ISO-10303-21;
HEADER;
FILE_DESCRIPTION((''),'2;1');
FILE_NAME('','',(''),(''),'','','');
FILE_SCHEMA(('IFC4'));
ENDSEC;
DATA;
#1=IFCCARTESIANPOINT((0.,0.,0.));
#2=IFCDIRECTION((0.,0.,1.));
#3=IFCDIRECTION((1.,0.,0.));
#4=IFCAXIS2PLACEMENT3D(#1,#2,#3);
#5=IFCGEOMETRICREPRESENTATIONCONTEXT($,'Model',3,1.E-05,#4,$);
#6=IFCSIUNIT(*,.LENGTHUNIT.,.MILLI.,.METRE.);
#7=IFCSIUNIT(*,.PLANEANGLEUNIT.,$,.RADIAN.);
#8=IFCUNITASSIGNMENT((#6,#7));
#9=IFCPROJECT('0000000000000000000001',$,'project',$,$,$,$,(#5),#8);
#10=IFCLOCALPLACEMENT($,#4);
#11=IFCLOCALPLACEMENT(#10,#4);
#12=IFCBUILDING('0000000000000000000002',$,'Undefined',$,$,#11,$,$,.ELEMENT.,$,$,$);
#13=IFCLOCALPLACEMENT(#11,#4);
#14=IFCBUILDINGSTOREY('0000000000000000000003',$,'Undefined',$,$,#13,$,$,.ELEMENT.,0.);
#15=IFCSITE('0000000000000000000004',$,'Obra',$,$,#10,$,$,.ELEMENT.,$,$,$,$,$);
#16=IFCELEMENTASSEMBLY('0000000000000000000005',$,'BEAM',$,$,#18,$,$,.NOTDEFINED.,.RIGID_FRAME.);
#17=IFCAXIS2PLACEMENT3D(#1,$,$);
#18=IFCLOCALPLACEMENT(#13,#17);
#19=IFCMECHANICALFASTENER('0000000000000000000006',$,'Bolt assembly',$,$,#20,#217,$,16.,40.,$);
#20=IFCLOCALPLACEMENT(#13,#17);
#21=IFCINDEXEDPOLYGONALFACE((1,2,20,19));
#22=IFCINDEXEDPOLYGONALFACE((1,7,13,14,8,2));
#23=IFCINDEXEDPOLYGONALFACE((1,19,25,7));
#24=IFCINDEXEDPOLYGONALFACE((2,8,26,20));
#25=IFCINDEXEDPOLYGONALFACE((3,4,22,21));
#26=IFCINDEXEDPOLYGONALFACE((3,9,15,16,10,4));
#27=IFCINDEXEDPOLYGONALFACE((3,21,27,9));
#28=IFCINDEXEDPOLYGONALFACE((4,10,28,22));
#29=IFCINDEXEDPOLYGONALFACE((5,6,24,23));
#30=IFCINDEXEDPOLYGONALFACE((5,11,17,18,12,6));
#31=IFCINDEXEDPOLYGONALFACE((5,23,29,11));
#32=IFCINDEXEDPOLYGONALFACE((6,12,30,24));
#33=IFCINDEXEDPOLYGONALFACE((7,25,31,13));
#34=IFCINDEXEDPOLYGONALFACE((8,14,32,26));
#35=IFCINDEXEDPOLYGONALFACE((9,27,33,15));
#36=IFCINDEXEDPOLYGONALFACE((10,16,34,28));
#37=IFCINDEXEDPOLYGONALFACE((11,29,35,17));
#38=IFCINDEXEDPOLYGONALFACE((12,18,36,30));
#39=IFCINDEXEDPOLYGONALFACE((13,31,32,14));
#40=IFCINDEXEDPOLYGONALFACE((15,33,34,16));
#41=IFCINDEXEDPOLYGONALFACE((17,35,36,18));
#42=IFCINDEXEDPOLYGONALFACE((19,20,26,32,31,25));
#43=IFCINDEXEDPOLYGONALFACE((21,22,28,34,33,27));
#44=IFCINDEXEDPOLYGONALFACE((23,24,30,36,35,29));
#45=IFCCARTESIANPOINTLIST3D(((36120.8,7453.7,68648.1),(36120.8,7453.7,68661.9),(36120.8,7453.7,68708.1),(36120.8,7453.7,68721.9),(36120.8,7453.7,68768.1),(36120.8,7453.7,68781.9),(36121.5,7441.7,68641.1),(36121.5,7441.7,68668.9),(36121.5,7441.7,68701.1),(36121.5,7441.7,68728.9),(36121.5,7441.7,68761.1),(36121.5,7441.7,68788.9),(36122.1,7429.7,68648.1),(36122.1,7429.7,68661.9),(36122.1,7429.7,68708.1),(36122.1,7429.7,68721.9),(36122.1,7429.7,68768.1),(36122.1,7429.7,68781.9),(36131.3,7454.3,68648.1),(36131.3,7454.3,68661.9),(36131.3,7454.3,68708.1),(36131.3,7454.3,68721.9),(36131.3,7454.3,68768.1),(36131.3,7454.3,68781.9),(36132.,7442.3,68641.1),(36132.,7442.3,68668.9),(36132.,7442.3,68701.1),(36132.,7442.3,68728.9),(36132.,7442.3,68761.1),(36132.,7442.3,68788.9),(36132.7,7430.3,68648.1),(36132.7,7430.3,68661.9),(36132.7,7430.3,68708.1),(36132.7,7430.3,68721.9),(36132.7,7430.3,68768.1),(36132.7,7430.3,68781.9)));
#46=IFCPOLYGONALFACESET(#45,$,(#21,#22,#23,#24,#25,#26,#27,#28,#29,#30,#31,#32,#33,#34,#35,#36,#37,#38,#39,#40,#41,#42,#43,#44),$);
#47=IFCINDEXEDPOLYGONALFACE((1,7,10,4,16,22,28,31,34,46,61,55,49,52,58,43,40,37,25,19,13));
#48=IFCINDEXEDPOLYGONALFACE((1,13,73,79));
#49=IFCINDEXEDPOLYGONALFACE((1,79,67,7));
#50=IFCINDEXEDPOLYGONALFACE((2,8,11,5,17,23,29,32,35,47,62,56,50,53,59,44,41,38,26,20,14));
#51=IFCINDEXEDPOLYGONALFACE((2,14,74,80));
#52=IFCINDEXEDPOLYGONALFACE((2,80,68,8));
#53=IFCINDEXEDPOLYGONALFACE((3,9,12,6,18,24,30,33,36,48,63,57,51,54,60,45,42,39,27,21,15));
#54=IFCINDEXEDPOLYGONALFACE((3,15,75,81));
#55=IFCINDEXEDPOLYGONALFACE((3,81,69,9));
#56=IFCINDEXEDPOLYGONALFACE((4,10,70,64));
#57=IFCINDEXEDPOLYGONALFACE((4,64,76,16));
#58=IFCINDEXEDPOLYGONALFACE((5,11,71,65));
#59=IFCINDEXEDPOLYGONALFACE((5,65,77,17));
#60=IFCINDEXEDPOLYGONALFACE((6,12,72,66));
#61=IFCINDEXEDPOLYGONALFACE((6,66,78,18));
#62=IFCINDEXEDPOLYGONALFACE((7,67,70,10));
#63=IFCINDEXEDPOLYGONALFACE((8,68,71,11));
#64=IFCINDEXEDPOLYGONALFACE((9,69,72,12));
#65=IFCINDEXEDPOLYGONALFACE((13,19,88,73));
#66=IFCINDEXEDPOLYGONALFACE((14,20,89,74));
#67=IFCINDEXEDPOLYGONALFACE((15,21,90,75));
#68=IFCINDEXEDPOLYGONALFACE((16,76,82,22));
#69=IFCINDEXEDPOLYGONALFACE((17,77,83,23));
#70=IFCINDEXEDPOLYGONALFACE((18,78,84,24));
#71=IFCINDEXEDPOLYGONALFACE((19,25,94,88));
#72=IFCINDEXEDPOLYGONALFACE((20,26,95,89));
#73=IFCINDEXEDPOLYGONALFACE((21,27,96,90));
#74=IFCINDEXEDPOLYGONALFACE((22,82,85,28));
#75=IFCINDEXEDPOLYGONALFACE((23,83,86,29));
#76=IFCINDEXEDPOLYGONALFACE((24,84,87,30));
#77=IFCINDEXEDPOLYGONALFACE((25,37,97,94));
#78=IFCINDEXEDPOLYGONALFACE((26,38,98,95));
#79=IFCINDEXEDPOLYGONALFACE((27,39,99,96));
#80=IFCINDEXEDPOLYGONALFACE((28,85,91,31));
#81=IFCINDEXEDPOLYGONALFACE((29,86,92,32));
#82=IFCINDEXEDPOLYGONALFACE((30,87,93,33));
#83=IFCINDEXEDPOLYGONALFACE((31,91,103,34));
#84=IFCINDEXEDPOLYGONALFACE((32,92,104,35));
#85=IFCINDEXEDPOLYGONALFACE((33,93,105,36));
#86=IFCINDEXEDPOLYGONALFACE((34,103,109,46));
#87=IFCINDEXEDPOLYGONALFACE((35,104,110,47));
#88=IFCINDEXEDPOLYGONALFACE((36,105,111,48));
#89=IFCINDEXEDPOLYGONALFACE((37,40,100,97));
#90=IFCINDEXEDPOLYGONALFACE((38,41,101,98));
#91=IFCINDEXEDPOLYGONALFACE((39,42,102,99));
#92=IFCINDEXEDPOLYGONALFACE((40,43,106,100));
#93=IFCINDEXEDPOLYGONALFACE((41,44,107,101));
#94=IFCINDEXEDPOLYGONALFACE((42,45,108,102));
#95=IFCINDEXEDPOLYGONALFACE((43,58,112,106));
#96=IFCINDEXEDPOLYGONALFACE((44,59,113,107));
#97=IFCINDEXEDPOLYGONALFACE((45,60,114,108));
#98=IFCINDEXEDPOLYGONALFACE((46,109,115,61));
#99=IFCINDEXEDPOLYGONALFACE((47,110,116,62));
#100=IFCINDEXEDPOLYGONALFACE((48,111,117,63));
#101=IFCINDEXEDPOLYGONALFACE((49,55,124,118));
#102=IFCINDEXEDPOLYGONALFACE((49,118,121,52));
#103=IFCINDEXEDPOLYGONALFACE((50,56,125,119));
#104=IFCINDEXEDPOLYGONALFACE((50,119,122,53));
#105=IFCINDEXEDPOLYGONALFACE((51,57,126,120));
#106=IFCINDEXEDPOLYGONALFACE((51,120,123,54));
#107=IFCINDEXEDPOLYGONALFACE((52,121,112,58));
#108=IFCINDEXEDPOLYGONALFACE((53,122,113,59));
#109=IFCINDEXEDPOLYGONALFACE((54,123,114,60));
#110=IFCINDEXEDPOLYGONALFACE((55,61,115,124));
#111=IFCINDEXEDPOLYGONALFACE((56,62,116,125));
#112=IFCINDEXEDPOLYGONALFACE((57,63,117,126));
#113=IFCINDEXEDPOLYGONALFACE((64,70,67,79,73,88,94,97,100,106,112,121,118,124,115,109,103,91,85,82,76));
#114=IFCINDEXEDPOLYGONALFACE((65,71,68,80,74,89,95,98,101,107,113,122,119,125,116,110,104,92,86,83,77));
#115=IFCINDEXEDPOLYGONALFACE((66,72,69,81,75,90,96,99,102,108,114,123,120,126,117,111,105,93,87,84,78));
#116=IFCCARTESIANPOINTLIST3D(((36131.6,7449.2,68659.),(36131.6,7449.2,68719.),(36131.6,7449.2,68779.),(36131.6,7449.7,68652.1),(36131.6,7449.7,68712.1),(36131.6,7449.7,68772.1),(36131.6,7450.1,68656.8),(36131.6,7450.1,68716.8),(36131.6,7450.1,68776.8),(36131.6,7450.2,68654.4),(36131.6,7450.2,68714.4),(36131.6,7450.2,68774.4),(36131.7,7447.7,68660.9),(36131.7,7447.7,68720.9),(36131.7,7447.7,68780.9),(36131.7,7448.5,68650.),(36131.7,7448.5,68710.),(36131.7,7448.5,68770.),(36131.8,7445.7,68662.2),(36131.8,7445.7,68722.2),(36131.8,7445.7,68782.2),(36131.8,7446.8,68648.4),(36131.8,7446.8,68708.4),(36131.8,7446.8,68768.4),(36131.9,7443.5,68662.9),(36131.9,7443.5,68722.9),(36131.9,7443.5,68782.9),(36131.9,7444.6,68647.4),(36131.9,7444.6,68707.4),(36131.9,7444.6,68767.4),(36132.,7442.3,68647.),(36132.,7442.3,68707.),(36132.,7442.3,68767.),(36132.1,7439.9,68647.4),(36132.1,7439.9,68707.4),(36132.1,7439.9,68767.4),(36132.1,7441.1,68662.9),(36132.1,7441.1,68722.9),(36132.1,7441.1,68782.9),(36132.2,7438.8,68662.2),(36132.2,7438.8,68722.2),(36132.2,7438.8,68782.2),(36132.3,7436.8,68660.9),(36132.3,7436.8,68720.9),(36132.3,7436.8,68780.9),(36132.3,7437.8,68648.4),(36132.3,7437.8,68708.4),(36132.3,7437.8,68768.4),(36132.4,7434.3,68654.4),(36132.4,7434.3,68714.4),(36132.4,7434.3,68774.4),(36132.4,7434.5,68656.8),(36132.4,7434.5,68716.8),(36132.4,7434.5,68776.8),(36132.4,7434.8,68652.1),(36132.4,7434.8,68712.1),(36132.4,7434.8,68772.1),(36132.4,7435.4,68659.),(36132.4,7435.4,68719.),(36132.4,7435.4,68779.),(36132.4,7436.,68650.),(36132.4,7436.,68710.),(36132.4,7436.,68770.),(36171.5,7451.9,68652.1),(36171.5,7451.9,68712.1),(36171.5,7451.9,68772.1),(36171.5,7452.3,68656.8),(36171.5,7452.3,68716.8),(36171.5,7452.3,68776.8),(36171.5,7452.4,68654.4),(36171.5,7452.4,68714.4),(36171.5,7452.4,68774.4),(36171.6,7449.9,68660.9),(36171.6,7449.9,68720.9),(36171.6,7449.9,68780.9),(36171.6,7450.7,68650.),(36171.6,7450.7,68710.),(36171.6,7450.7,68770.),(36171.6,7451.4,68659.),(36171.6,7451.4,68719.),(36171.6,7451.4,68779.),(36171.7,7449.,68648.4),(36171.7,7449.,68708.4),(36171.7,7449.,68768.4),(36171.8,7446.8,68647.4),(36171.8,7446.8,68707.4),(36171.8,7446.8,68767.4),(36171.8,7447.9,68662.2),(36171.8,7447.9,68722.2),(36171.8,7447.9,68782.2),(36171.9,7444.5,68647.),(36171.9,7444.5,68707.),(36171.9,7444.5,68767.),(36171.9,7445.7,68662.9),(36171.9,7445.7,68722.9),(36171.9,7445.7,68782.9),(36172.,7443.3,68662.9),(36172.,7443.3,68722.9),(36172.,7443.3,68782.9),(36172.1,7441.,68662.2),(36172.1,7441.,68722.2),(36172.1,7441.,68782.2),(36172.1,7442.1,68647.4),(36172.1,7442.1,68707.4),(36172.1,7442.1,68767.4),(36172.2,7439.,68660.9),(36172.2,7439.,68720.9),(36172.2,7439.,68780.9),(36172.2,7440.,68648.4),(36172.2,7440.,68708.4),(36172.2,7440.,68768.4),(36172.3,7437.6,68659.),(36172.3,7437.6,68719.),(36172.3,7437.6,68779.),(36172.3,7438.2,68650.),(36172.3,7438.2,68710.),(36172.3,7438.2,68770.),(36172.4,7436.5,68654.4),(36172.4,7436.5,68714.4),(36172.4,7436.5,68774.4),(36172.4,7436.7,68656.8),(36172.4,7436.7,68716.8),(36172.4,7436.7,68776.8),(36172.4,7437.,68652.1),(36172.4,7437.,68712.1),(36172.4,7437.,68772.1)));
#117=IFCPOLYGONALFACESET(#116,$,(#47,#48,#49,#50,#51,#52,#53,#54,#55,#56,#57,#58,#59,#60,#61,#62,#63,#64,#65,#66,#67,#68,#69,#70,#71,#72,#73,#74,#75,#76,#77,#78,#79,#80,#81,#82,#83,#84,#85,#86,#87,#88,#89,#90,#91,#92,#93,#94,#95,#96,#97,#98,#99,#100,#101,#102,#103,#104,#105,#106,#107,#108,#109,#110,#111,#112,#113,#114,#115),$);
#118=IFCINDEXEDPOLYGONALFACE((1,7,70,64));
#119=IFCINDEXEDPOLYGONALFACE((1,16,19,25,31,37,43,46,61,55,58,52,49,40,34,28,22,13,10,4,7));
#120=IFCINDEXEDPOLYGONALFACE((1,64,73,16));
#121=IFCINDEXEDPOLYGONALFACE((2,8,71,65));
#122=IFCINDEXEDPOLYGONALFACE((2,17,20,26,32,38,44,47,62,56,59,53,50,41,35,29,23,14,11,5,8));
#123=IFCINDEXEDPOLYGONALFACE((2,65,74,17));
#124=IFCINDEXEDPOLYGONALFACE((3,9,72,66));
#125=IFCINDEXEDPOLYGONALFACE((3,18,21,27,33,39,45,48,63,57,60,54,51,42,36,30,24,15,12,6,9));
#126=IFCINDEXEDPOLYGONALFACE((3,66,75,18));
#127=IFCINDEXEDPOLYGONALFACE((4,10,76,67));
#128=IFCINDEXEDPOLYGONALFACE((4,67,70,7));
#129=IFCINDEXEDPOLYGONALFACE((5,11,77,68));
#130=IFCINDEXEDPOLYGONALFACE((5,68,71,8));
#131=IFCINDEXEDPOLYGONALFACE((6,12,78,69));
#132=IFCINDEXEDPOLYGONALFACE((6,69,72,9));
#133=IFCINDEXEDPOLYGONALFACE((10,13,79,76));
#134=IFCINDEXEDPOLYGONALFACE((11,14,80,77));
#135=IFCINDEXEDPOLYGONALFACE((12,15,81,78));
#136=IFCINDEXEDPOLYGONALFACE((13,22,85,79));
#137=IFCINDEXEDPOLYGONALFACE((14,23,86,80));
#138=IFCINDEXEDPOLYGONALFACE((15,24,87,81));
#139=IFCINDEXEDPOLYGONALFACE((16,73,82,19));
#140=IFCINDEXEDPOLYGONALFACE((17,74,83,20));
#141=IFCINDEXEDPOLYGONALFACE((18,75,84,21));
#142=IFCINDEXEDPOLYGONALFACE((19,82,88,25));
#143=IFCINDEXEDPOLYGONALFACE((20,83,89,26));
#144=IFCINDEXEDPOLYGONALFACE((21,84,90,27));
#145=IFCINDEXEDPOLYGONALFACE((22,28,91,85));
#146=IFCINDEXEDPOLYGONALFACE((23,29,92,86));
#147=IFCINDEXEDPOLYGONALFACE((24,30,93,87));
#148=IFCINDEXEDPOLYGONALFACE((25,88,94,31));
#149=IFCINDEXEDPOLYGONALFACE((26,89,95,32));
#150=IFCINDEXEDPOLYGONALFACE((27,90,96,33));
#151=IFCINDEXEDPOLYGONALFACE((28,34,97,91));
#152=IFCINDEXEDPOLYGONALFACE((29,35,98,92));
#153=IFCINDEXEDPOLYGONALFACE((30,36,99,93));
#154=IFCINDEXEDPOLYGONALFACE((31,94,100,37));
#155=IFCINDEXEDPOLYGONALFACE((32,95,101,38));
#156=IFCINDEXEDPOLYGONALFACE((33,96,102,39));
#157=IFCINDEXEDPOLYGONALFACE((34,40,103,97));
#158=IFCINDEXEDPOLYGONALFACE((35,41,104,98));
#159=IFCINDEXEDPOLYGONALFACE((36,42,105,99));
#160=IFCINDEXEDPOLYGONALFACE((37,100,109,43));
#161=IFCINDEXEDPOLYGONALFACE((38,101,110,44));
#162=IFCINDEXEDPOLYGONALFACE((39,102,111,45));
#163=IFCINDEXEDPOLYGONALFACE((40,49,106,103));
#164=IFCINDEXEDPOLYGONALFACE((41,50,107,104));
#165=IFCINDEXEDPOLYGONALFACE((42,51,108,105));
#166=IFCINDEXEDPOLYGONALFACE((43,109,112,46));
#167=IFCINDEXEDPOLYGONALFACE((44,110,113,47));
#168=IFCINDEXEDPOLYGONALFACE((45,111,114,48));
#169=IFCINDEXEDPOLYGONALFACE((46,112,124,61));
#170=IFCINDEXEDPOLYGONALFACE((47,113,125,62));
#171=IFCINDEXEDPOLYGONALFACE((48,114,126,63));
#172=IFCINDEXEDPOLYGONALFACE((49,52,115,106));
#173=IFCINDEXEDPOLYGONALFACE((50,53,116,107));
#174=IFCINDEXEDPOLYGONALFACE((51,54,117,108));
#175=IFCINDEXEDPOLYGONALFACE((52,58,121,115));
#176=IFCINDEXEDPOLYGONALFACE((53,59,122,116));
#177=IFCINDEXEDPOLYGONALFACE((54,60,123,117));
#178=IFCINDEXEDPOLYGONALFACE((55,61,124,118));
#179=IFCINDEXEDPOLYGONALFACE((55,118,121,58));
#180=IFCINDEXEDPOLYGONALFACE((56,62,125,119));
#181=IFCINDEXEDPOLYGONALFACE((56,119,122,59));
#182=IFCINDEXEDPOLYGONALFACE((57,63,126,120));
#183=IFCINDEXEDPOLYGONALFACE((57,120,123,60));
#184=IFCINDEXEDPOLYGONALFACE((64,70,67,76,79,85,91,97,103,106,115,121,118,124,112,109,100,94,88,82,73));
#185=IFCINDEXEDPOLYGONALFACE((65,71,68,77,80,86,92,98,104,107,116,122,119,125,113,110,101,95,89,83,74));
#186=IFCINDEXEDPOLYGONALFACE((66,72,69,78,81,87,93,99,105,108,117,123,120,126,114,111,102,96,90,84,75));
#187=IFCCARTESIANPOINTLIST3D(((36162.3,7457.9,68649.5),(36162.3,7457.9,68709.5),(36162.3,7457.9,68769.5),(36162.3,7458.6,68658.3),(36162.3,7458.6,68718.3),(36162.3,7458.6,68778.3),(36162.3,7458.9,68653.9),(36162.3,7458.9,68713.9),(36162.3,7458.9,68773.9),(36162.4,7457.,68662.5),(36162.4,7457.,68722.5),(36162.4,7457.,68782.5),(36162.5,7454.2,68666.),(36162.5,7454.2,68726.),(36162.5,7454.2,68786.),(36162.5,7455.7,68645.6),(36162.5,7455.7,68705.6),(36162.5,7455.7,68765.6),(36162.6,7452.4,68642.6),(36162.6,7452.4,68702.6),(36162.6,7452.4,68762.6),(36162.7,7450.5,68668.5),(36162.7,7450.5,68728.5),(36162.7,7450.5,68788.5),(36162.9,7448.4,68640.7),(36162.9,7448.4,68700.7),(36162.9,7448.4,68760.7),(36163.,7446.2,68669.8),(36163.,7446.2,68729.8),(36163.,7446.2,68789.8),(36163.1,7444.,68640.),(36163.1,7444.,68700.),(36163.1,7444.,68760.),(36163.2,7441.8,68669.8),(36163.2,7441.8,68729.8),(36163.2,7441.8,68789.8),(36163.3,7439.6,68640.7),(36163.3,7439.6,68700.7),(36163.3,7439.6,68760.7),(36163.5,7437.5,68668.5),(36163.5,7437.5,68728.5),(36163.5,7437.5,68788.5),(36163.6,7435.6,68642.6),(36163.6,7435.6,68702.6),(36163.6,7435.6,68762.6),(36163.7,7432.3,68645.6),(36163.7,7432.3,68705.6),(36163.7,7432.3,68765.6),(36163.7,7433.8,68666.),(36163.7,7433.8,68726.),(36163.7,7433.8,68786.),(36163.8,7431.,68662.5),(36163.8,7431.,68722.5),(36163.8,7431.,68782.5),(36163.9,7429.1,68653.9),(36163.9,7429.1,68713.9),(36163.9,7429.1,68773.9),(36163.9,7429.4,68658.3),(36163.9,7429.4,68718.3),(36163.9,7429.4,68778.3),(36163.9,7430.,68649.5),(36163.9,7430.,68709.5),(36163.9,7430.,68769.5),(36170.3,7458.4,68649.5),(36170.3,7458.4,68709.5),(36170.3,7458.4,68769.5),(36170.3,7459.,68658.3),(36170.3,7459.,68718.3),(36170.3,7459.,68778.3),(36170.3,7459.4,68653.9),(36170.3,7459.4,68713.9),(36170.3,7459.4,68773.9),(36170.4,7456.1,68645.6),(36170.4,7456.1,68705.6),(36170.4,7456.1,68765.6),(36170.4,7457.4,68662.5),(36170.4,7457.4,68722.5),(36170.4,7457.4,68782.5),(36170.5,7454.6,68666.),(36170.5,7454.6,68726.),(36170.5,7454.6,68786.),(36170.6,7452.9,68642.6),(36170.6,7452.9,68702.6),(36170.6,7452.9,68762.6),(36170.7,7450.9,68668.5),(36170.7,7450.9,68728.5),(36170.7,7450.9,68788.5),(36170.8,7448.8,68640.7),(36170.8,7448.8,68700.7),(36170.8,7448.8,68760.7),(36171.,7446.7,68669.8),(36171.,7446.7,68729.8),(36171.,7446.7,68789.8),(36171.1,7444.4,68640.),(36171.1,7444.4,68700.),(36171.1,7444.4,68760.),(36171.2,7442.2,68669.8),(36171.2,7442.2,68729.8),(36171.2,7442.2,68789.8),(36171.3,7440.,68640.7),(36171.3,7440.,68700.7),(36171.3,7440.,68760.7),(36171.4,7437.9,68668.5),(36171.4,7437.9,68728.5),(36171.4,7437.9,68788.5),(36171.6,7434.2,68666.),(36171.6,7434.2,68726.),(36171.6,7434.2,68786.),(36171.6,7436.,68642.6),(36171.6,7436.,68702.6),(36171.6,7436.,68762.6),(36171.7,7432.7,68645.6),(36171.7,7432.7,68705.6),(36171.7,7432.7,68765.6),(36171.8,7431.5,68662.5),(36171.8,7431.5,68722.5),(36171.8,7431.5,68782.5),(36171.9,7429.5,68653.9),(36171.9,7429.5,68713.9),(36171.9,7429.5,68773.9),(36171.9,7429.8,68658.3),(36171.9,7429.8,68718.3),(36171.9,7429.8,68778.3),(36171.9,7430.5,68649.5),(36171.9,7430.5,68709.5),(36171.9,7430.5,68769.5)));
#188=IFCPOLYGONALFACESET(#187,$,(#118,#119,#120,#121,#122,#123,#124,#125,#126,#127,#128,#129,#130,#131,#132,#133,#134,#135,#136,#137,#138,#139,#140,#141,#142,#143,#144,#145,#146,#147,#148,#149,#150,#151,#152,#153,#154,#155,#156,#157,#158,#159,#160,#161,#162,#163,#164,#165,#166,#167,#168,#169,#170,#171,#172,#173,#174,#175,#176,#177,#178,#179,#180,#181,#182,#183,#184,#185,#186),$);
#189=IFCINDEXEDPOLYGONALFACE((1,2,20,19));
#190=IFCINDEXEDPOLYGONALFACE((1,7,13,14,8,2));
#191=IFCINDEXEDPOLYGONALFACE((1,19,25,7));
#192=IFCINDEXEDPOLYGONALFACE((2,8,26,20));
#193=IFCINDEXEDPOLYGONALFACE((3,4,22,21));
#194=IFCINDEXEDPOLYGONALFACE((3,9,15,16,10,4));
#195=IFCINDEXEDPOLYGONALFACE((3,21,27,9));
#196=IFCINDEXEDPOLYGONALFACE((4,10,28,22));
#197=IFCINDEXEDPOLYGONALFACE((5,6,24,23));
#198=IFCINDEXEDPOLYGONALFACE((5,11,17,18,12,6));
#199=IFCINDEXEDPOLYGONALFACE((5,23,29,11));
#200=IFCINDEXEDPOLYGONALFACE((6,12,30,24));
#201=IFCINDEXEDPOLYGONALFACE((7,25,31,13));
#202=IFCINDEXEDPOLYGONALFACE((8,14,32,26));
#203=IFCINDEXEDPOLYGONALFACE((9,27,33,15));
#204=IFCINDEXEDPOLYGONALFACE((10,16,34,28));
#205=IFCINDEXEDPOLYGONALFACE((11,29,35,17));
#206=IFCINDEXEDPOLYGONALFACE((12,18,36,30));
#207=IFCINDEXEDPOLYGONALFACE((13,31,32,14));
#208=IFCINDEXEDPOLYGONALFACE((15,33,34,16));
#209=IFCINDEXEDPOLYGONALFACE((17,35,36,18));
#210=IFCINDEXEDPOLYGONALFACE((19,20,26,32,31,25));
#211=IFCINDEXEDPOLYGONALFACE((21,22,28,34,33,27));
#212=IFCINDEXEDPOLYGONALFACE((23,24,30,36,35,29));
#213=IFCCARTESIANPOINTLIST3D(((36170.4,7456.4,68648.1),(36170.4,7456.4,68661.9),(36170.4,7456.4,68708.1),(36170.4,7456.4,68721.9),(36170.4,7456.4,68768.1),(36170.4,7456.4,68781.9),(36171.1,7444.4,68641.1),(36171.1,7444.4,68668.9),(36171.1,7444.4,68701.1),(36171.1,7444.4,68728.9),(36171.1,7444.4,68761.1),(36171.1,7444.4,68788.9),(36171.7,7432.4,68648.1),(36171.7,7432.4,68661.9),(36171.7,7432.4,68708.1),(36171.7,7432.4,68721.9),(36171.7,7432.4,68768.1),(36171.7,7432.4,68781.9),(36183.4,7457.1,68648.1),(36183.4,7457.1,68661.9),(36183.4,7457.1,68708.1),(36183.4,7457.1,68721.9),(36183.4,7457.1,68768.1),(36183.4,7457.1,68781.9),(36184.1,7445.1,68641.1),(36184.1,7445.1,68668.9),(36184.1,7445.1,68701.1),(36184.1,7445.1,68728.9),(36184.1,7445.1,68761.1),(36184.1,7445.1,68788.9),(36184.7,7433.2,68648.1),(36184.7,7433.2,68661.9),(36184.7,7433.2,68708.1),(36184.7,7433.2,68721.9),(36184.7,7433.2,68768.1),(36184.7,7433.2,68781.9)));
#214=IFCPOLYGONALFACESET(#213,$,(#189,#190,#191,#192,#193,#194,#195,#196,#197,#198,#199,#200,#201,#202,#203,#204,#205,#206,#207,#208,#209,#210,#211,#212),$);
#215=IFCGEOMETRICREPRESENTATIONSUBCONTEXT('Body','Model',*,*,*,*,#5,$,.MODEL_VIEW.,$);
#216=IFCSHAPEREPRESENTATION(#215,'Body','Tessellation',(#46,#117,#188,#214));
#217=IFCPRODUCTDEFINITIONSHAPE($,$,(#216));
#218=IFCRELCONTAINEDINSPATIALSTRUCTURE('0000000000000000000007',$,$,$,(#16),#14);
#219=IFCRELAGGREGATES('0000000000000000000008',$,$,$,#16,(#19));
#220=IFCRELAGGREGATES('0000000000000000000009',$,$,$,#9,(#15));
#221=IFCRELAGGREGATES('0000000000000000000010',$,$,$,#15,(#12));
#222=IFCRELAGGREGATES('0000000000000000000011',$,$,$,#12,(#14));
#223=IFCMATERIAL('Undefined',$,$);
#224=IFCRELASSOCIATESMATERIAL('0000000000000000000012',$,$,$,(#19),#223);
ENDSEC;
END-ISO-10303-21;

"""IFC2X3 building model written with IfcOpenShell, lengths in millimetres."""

from ifc_helpers import new_model, si_unit, frame, origin_with_axes, origin_2d_with_axis, place, context, subcontext, project, spatial, polyline, circle, outline, extrude, source, transform, mapped, material, element, aggregate, save


model = new_model("IFC2X3")

# Units and contexts
model_context = context("Model", 3, precision=1e-05, world=origin_with_axes())
body_context = subcontext(model_context, "Body", "Model", "MODEL_VIEW")
ifc_project = project(units=[si_unit("LENGTHUNIT", "METRE", prefix="MILLI"), si_unit("PLANEANGLEUNIT", "RADIAN")], contexts=[model_context])

# Site, building, storey
site_placement = place(None, origin_with_axes())
site = spatial("IfcSite", under=ifc_project, at=site_placement, Name="Obra", CompositionType="ELEMENT")
building_placement = place(site_placement, origin_with_axes())
building = spatial("IfcBuilding", under=site, at=building_placement, Name="Undefined", CompositionType="ELEMENT")
storey_placement = place(building_placement, origin_with_axes())
storey = spatial("IfcBuildingStorey", under=building, at=storey_placement, Name="Undefined", CompositionType="ELEMENT", Elevation=0.0)

# Shared definitions
ifc_material_1 = material(Name="Undefined")
shared_shape_1 = source(origin_with_axes(), body_context, "Body", "SweptSolid", [
    extrude(outline(polyline([(13.9, 0.0), (6.9, 12.0), (-6.9, 12.0), (-13.9, 0.0), (-6.9, -12.0), (6.9, -12.0), (13.9, 0.0)])), frame((0.0, -44.8, 0.0), z_axis=(0.0, 1.0, 0.0), x_axis=(1.0, 0.0, 0.0)), (0.0, 0.0, 1.0), 10.6),
    extrude(circle(Radius=8.0, at=origin_2d_with_axis()), frame((0.0, -34.2, 0.0), z_axis=(0.0, 1.0, 0.0), x_axis=(1.0, 0.0, 0.0)), (0.0, 0.0, 1.0), 40.0),
    extrude(circle(Radius=15.0, at=origin_2d_with_axis()), frame((0.0, -3.1, 0.0), z_axis=(0.0, 1.0, 0.0), x_axis=(1.0, 0.0, 0.0)), (0.0, 0.0, 1.0), 8.0),
    extrude(outline(polyline([(13.9, 0.0), (6.9, 12.0), (-6.9, 12.0), (-13.9, 0.0), (-6.9, -12.0), (6.9, -12.0), (13.9, 0.0)])), frame((0.0, 4.9, 0.0), z_axis=(0.0, 1.0, 0.0), x_axis=(1.0, 0.0, 0.0)), (0.0, 0.0, 1.0), 13.0),
])

# Element assembly, mechanical fastener
assembly_1_placement = place(storey_placement, origin_with_axes())
assembly_1 = element("IfcElementAssembly", 1, at=assembly_1_placement, inside=storey, Name="BEAM", AssemblyPlace="NOTDEFINED", PredefinedType="RIGID_FRAME")
mechanical_fastener_1_placement = place(assembly_1_placement, frame((36163.4, 7494.1, 68835.0), z_axis=(0.055152, -0.998478, 0.0), x_axis=(0.0, 0.0, -1.0)))
mechanical_fastener_1 = element("IfcMechanicalFastener", 2, at=mechanical_fastener_1_placement, material=ifc_material_1, Name="Bolt assembly", NominalDiameter=16.0, NominalLength=40.0, context=body_context, shape_type="MappedRepresentation", body=[
    mapped(shared_shape_1, transform((60.0, 0.0, 50.0))),
    mapped(shared_shape_1, transform((120.0, 0.0, 50.0))),
    mapped(shared_shape_1, transform((180.0, 0.0, 50.0))),
])
aggregate(assembly_1, [mechanical_fastener_1])

save(model, "model.ifc")
